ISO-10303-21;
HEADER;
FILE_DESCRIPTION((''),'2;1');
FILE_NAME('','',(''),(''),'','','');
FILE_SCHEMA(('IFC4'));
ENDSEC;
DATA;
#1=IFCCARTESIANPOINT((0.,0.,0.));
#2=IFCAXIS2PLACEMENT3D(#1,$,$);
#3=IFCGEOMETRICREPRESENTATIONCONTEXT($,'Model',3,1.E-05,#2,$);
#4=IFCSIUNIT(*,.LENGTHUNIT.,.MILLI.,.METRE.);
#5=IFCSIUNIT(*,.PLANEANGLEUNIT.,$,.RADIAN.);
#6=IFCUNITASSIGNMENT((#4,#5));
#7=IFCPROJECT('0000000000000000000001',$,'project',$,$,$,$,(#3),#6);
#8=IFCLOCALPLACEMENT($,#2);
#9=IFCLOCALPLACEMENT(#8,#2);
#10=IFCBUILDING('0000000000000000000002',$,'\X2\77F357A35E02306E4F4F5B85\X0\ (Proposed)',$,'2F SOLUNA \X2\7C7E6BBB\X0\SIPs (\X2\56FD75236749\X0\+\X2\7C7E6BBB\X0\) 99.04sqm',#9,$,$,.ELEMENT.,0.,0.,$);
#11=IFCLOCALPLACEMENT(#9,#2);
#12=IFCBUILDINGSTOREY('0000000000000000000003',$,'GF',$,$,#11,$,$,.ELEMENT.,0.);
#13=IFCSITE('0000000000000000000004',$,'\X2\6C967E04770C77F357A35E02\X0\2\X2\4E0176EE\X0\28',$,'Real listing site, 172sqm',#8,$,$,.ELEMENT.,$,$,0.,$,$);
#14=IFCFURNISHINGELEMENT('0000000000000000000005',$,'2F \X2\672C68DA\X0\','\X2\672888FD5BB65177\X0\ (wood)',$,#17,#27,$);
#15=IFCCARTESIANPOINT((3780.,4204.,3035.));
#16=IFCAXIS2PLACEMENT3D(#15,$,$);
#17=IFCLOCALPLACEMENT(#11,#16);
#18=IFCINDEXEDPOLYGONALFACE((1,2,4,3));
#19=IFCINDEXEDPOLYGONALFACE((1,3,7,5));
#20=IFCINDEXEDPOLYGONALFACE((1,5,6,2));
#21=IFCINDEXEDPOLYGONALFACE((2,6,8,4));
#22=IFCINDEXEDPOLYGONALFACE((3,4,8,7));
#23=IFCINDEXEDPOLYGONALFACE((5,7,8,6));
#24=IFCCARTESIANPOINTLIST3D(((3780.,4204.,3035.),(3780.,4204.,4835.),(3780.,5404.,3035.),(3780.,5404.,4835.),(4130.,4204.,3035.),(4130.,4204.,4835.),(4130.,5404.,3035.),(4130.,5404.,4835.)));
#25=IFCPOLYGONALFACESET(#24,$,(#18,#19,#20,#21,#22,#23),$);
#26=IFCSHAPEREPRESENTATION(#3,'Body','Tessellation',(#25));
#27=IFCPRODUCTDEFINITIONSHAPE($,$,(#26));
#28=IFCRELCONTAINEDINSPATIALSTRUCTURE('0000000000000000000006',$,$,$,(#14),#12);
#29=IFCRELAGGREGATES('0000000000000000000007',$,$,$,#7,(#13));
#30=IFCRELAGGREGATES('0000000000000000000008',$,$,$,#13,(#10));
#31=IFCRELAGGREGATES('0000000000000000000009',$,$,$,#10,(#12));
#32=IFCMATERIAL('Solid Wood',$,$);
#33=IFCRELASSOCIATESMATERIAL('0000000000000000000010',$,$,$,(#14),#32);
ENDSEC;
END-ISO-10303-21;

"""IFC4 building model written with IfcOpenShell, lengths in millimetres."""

from ifc_helpers import new_model, si_unit, frame, frame_2d, origin, place, context, project, spatial, rectangle, extrude, material, element, save


model = new_model("IFC4")

# Units and contexts
model_context = context("Model", 3, precision=1e-05, world=origin())
ifc_project = project(units=[si_unit("LENGTHUNIT", "METRE", prefix="MILLI"), si_unit("PLANEANGLEUNIT", "RADIAN")], contexts=[model_context])

# Site, building, storey
site_placement = place(None, origin())
site = spatial("IfcSite", under=ifc_project, at=site_placement, Name="沖縄県石垣市2丁目28", ObjectType="Real listing site, 172sqm", CompositionType="ELEMENT", RefElevation=0.0)
building_placement = place(site_placement, origin())
building = spatial("IfcBuilding", under=site, at=building_placement, Name="石垣市の住宅 (Proposed)", ObjectType="2F SOLUNA 籾殻SIPs (国産杉+籾殻) 99.04sqm", CompositionType="ELEMENT", ElevationOfRefHeight=0.0, ElevationOfTerrain=0.0)
storey_placement = place(building_placement, origin())
storey = spatial("IfcBuildingStorey", under=building, at=storey_placement, Name="GF", CompositionType="ELEMENT", Elevation=0.0)

# Shared definitions
ifc_material_1 = material(Name="Solid Wood")

# Furnishing element
furnishing_placement = place(storey_placement, frame((3780.0, 4204.0, 3035.0)))
element("IfcFurnishingElement", 1, at=furnishing_placement, inside=storey, material=ifc_material_1, Name="2F 本棚", Description="木製家具 (wood)", context=model_context, shape_type="SweptSolid", body=[
    extrude(rectangle(XDim=350.0, YDim=1200.0, at=frame_2d((175.0, 600.0))), frame((3780.0, 4204.0, 3035.0)), (0.0, 0.0, 1.0), 1800.0),
])

save(model, "model.ifc")
